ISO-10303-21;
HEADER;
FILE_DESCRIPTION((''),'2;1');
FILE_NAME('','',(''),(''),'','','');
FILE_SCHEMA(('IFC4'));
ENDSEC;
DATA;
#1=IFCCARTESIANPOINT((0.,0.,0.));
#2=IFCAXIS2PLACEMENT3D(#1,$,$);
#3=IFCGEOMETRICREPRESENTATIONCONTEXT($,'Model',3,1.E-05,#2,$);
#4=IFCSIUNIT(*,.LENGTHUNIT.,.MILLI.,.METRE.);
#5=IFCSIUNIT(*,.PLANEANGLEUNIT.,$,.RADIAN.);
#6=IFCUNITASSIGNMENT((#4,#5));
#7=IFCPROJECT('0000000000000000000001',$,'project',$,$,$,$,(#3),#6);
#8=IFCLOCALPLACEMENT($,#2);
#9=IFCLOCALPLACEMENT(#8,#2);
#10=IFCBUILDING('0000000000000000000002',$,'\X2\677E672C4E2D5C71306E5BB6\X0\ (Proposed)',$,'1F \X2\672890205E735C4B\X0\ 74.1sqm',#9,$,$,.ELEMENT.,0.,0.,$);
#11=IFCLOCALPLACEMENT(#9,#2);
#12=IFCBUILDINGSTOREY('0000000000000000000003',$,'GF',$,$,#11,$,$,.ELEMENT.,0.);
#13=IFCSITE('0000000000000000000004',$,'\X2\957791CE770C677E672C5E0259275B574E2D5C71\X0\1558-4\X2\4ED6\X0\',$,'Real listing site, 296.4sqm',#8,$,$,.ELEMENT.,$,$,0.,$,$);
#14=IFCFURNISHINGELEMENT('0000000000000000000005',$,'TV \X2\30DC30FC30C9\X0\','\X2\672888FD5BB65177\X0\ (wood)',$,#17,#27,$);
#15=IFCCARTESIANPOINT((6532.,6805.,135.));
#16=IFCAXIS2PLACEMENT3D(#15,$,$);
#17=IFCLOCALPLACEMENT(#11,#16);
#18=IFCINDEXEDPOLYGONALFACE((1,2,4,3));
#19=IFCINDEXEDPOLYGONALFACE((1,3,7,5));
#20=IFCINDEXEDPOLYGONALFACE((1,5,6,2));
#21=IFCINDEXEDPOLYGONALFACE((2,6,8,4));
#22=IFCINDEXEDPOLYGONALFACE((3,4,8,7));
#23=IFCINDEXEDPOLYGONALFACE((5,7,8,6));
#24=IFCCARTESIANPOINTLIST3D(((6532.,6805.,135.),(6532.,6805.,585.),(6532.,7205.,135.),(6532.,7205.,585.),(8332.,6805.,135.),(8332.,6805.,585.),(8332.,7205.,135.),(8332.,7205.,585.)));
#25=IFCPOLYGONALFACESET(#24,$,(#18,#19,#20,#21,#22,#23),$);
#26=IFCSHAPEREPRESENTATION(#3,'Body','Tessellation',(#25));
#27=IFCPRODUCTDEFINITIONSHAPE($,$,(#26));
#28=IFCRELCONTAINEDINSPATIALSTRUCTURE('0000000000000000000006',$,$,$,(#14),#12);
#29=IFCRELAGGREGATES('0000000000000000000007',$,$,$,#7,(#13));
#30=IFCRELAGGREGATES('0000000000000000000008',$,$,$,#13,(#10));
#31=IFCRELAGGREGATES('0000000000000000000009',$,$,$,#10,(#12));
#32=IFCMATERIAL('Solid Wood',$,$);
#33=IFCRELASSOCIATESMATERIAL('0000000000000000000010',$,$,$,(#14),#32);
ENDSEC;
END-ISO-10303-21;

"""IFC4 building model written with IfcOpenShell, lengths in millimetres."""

from ifc_helpers import new_model, si_unit, frame, frame_2d, origin, place, context, project, spatial, rectangle, extrude, material, element, save


model = new_model("IFC4")

# Units and contexts
model_context = context("Model", 3, precision=1e-05, world=origin())
ifc_project = project(units=[si_unit("LENGTHUNIT", "METRE", prefix="MILLI"), si_unit("PLANEANGLEUNIT", "RADIAN")], contexts=[model_context])

# Site, building, storey
site_placement = place(None, origin())
site = spatial("IfcSite", under=ifc_project, at=site_placement, Name="長野県松本市大字中山1558-4他", ObjectType="Real listing site, 296.4sqm", CompositionType="ELEMENT", RefElevation=0.0)
building_placement = place(site_placement, origin())
building = spatial("IfcBuilding", under=site, at=building_placement, Name="松本中山の家 (Proposed)", ObjectType="1F 木造平屋 74.1sqm", CompositionType="ELEMENT", ElevationOfRefHeight=0.0, ElevationOfTerrain=0.0)
storey_placement = place(building_placement, origin())
storey = spatial("IfcBuildingStorey", under=building, at=storey_placement, Name="GF", CompositionType="ELEMENT", Elevation=0.0)

# Shared definitions
ifc_material_1 = material(Name="Solid Wood")

# Furnishing element
furnishing_1_placement = place(storey_placement, frame((6532.0, 6805.0, 135.0)))
element("IfcFurnishingElement", 1, at=furnishing_1_placement, inside=storey, material=ifc_material_1, Name="TV ボード", Description="木製家具 (wood)", context=model_context, shape_type="SweptSolid", body=[
    extrude(rectangle(XDim=1800.0, YDim=400.0, at=frame_2d((900.0, 200.0))), frame((6532.0, 6805.0, 135.0)), (0.0, 0.0, 1.0), 450.0),
])

save(model, "model.ifc")
